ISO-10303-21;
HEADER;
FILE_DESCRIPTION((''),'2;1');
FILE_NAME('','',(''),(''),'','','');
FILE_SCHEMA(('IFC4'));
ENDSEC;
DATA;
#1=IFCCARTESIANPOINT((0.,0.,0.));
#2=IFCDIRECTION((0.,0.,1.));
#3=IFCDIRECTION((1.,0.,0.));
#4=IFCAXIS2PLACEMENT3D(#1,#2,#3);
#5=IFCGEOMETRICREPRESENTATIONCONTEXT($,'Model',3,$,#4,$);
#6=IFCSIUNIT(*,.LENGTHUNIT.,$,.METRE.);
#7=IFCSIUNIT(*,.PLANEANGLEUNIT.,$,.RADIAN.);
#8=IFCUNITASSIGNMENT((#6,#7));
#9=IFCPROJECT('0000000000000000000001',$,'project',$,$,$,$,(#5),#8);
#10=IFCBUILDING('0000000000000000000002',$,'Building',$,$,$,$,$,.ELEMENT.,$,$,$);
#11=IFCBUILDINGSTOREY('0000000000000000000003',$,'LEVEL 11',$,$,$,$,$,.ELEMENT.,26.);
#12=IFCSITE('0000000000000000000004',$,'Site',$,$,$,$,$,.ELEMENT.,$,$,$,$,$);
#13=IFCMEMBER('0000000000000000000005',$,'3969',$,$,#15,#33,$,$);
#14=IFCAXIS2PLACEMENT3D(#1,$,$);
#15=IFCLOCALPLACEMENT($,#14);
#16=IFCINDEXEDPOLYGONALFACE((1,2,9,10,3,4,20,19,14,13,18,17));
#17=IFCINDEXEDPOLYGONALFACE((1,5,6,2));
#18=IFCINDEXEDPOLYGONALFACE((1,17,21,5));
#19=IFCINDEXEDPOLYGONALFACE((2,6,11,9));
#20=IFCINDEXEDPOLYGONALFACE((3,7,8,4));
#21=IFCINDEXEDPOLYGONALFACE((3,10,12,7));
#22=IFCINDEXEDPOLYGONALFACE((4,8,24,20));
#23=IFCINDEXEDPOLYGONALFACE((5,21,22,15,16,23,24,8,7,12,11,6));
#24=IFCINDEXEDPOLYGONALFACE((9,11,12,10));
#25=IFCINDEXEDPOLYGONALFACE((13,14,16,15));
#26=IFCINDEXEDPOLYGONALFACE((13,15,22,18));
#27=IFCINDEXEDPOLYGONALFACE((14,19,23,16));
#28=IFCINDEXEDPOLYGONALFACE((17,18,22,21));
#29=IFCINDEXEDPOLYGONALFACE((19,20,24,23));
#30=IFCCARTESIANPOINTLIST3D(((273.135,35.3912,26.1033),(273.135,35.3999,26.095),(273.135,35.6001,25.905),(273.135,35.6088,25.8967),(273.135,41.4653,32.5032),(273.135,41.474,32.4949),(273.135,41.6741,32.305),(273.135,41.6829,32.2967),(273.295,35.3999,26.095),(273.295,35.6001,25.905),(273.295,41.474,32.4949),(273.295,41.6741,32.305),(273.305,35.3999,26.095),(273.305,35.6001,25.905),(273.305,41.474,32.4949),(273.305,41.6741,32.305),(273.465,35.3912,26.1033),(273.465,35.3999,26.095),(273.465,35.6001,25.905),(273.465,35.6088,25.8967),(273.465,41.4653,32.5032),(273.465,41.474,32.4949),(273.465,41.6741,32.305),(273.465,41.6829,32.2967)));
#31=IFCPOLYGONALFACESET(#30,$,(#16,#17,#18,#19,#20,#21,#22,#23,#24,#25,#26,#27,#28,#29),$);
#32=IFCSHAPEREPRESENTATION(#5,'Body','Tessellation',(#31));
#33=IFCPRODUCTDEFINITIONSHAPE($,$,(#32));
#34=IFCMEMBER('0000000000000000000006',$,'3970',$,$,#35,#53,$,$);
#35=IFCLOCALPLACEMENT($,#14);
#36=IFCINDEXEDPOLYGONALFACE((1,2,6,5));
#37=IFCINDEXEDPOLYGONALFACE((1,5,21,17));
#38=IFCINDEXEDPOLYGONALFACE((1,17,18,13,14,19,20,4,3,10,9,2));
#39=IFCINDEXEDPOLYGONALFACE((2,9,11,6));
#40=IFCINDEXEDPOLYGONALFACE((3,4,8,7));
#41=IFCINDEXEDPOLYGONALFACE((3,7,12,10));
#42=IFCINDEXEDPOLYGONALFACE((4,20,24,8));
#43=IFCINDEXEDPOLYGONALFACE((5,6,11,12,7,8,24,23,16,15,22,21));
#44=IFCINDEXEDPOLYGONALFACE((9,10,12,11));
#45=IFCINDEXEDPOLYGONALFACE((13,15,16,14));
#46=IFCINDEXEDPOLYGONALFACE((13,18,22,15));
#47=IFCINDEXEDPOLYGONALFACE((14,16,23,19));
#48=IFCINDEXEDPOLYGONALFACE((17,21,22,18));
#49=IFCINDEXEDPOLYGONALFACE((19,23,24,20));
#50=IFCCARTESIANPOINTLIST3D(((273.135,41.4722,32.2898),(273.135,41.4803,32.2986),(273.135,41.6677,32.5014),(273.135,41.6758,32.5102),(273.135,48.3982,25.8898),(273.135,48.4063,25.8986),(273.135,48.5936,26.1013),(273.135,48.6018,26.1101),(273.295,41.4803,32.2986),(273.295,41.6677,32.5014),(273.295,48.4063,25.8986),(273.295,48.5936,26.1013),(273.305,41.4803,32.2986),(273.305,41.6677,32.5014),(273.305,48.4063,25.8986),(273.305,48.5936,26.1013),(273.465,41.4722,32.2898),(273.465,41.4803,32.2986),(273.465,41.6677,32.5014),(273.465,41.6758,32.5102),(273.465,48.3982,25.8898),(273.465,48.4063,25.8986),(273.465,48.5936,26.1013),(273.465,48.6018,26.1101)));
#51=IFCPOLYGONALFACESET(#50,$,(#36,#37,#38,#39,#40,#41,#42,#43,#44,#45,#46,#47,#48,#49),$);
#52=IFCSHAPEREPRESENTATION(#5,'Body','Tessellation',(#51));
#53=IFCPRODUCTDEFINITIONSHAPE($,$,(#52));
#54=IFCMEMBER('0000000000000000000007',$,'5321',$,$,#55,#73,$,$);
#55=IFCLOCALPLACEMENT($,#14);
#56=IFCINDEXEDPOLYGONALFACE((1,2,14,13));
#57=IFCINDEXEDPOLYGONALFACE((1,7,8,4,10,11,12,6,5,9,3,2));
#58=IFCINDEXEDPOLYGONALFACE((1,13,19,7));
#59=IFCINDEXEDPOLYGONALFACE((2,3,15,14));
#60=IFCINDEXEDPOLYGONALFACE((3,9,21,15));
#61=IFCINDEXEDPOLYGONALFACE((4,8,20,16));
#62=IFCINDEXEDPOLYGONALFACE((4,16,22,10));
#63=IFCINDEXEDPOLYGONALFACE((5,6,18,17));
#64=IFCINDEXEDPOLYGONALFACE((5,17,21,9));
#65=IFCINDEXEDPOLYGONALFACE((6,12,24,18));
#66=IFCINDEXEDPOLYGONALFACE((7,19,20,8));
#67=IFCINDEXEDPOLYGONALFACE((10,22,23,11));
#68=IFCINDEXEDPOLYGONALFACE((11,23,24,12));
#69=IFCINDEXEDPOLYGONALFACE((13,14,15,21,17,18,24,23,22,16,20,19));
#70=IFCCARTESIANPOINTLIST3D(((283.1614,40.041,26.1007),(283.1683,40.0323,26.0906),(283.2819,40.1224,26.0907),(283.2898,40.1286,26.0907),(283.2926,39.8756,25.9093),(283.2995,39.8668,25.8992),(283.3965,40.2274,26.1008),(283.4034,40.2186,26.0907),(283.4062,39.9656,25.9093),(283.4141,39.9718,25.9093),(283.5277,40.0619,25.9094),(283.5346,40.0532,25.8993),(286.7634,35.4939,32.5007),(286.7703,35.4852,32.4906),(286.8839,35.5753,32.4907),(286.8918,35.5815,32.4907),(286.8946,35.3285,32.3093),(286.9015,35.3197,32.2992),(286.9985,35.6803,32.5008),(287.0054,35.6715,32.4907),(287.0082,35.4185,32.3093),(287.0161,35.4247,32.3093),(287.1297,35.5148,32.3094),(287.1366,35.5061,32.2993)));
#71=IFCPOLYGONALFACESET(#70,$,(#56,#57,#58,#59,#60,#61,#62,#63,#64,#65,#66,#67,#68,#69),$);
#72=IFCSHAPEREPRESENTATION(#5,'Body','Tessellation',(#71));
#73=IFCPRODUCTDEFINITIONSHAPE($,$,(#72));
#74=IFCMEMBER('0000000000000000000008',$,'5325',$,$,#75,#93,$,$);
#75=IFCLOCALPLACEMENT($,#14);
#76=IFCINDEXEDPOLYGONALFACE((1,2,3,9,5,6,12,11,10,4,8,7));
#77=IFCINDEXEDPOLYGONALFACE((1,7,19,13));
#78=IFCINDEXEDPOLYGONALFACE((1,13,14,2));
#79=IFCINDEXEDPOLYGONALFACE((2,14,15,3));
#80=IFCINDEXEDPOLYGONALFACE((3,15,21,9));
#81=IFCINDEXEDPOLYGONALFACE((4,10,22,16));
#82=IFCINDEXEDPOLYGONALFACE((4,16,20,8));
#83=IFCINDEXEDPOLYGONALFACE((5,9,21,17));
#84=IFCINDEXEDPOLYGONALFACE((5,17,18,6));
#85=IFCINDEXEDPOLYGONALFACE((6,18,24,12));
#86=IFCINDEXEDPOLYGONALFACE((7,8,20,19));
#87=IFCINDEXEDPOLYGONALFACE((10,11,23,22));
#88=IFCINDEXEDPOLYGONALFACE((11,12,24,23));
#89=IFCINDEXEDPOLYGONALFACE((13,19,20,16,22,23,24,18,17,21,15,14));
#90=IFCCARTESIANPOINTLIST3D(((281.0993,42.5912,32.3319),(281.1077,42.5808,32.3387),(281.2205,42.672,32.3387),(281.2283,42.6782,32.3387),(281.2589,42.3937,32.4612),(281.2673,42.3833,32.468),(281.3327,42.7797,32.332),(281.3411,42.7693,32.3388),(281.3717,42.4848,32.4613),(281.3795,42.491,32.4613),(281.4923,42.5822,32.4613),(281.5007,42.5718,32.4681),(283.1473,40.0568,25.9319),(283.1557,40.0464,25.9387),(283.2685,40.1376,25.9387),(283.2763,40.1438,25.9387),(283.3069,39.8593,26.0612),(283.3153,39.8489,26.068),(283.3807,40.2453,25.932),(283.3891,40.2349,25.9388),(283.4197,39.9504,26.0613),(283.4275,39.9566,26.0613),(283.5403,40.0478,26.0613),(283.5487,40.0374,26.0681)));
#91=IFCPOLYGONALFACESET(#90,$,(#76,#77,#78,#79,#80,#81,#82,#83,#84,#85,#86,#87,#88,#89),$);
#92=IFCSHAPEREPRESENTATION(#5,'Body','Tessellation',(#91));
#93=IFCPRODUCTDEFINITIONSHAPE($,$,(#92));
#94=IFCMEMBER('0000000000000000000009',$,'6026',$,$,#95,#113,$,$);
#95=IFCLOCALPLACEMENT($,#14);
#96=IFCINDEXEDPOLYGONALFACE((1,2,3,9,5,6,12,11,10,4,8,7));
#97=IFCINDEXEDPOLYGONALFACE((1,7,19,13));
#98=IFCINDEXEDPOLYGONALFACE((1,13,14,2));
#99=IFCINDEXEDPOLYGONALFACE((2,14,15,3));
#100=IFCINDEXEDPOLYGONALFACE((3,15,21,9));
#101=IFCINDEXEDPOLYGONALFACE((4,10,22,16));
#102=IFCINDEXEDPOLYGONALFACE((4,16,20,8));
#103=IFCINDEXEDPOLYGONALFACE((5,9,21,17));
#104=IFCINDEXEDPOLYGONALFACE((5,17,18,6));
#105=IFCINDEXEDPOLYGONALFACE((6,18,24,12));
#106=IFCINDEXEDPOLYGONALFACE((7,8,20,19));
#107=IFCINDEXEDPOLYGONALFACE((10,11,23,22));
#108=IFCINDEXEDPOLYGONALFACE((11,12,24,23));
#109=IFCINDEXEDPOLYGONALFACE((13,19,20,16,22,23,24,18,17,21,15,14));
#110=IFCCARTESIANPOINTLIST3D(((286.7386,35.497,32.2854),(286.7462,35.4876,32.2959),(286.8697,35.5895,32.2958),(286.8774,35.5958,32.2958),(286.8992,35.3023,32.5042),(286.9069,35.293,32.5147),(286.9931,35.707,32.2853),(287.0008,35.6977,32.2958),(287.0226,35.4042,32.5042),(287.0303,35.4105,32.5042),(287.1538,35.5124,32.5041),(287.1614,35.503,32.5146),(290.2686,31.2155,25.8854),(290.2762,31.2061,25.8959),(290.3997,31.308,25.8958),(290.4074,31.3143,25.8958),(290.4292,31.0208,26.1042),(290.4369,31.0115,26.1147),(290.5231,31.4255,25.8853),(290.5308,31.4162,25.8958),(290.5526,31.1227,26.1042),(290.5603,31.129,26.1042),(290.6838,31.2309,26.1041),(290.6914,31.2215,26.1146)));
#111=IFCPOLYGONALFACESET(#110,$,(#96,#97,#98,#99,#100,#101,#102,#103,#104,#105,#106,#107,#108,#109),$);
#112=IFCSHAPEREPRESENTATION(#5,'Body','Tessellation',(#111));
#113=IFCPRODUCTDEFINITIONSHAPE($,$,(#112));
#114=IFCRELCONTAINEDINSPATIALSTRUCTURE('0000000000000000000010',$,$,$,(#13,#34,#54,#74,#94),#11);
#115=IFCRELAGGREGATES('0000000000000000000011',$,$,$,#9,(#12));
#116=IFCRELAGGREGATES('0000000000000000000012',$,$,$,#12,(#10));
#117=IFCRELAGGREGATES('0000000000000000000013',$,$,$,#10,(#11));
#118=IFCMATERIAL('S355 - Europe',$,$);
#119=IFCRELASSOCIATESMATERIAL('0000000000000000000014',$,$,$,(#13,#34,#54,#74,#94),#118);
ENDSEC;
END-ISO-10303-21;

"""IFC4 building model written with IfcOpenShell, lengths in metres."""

from ifc_helpers import new_model, si_unit, frame, origin_with_axes, origin_2d_with_axis, place, context, project, spatial, i_section, extrude, material, material_profile, profile_set, profile_usage, element, save


model = new_model("IFC4")

# Units and contexts
model_context = context("Model", 3, world=origin_with_axes())
ifc_project = project(units=[si_unit("LENGTHUNIT", "METRE"), si_unit("PLANEANGLEUNIT", "RADIAN")], contexts=[model_context])

# Site, building, storey
site = spatial("IfcSite", under=ifc_project, Name="Site", CompositionType="ELEMENT")
building = spatial("IfcBuilding", under=site, Name="Building", CompositionType="ELEMENT")
storey = spatial("IfcBuildingStorey", under=building, Name="LEVEL 11", CompositionType="ELEMENT", Elevation=26.0)

# Shared definitions
ifc_material = material(Name="S355 - Europe")

# Members
ifc_material_profile_1 = material_profile(ifc_material, i_section(OverallWidth=0.33, OverallDepth=0.3, WebThickness=0.01, FlangeThickness=0.012, at=origin_2d_with_axis()))
ifc_profile_set_1 = profile_set([ifc_material_profile_1])
ifc_profile_usage_1 = profile_usage(ifc_profile_set_1, cardinal=10)
member_1_placement = place(None, frame((273.3, 35.5, 26.0), z_axis=(0.0, 0.688398, 0.725333), x_axis=(-1.0, 0.0, 0.0)))
element("IfcMember", 1, at=member_1_placement, inside=storey, material=ifc_profile_usage_1, Name="3969", context=model_context, shape_type="SweptSolid", body=[
    extrude(i_section(OverallWidth=0.33, OverallDepth=0.3, WebThickness=0.01, FlangeThickness=0.012, at=origin_2d_with_axis()), origin_with_axes(), (0.0, 0.0, 1.0), 8.8235),
])
ifc_material_profile_2 = material_profile(ifc_material, i_section(OverallWidth=0.33, OverallDepth=0.3, WebThickness=0.01, FlangeThickness=0.012, at=origin_2d_with_axis()))
ifc_profile_set_2 = profile_set([ifc_material_profile_2])
ifc_profile_usage_2 = profile_usage(ifc_profile_set_2, cardinal=10)
member_2_placement = place(None, frame((273.3, 41.574, 32.4), z_axis=(0.0, 0.734441, -0.678673), x_axis=(-1.0, 0.0, 0.0)))
element("IfcMember", 2, at=member_2_placement, inside=storey, material=ifc_profile_usage_2, Name="3970", context=model_context, shape_type="SweptSolid", body=[
    extrude(i_section(OverallWidth=0.33, OverallDepth=0.3, WebThickness=0.01, FlangeThickness=0.012, at=origin_2d_with_axis()), origin_with_axes(), (0.0, 0.0, 1.0), 9.4302),
])
ifc_material_profile_3 = material_profile(ifc_material, i_section(OverallWidth=0.3, OverallDepth=0.3, WebThickness=0.01, FlangeThickness=0.015, at=origin_2d_with_axis()))
ifc_profile_set_3 = profile_set([ifc_material_profile_3])
ifc_profile_usage_3 = profile_usage(ifc_profile_set_3, cardinal=10)
member_3_placement = place(None, frame((286.95, 35.5, 32.4), z_axis=(-0.417007, 0.526423, -0.740935), x_axis=(-0.783587, -0.621282, 0.0)))
element("IfcMember", 3, at=member_3_placement, inside=storey, material=ifc_profile_usage_3, Name="5321", context=model_context, shape_type="SweptSolid", body=[
    extrude(i_section(OverallWidth=0.3, OverallDepth=0.3, WebThickness=0.01, FlangeThickness=0.015, at=origin_2d_with_axis()), origin_with_axes(), (0.0, 0.0, 1.0), 8.6377),
])
ifc_material_profile_4 = material_profile(ifc_material, i_section(OverallWidth=0.3, OverallDepth=0.3, WebThickness=0.01, FlangeThickness=0.015, at=origin_2d_with_axis()))
ifc_profile_set_4 = profile_set([ifc_material_profile_4])
ifc_profile_usage_4 = profile_usage(ifc_profile_set_4, cardinal=10)
member_4_placement = place(None, frame((283.348, 40.0471, 26.0), z_axis=(-0.285167, 0.352895, 0.891148), x_axis=(-0.777987, -0.62828, 0.0)))
element("IfcMember", 4, at=member_4_placement, inside=storey, material=ifc_profile_usage_4, Name="5325", context=model_context, shape_type="SweptSolid", body=[
    extrude(i_section(OverallWidth=0.3, OverallDepth=0.3, WebThickness=0.01, FlangeThickness=0.015, at=origin_2d_with_axis()), origin_with_axes(), (0.0, 0.0, 1.0), 7.1817),
])
ifc_material_profile_5 = material_profile(ifc_material, i_section(OverallWidth=0.33, OverallDepth=0.35, WebThickness=0.01, FlangeThickness=0.016, at=origin_2d_with_axis()))
ifc_profile_set_5 = profile_set([ifc_material_profile_5])
ifc_profile_usage_5 = profile_usage(ifc_profile_set_5, cardinal=10)
member_5_placement = place(None, frame((290.48, 31.2185, 26.0), z_axis=(-0.416732, 0.50545, 0.755549), x_axis=(-0.771157, -0.636646, 0.0)))
element("IfcMember", 5, at=member_5_placement, inside=storey, material=ifc_profile_usage_5, Name="6026", context=model_context, shape_type="SweptSolid", body=[
    extrude(i_section(OverallWidth=0.33, OverallDepth=0.35, WebThickness=0.01, FlangeThickness=0.016, at=origin_2d_with_axis()), origin_with_axes(), (0.0, 0.0, 1.0), 8.4707),
])

save(model, "model.ifc")
